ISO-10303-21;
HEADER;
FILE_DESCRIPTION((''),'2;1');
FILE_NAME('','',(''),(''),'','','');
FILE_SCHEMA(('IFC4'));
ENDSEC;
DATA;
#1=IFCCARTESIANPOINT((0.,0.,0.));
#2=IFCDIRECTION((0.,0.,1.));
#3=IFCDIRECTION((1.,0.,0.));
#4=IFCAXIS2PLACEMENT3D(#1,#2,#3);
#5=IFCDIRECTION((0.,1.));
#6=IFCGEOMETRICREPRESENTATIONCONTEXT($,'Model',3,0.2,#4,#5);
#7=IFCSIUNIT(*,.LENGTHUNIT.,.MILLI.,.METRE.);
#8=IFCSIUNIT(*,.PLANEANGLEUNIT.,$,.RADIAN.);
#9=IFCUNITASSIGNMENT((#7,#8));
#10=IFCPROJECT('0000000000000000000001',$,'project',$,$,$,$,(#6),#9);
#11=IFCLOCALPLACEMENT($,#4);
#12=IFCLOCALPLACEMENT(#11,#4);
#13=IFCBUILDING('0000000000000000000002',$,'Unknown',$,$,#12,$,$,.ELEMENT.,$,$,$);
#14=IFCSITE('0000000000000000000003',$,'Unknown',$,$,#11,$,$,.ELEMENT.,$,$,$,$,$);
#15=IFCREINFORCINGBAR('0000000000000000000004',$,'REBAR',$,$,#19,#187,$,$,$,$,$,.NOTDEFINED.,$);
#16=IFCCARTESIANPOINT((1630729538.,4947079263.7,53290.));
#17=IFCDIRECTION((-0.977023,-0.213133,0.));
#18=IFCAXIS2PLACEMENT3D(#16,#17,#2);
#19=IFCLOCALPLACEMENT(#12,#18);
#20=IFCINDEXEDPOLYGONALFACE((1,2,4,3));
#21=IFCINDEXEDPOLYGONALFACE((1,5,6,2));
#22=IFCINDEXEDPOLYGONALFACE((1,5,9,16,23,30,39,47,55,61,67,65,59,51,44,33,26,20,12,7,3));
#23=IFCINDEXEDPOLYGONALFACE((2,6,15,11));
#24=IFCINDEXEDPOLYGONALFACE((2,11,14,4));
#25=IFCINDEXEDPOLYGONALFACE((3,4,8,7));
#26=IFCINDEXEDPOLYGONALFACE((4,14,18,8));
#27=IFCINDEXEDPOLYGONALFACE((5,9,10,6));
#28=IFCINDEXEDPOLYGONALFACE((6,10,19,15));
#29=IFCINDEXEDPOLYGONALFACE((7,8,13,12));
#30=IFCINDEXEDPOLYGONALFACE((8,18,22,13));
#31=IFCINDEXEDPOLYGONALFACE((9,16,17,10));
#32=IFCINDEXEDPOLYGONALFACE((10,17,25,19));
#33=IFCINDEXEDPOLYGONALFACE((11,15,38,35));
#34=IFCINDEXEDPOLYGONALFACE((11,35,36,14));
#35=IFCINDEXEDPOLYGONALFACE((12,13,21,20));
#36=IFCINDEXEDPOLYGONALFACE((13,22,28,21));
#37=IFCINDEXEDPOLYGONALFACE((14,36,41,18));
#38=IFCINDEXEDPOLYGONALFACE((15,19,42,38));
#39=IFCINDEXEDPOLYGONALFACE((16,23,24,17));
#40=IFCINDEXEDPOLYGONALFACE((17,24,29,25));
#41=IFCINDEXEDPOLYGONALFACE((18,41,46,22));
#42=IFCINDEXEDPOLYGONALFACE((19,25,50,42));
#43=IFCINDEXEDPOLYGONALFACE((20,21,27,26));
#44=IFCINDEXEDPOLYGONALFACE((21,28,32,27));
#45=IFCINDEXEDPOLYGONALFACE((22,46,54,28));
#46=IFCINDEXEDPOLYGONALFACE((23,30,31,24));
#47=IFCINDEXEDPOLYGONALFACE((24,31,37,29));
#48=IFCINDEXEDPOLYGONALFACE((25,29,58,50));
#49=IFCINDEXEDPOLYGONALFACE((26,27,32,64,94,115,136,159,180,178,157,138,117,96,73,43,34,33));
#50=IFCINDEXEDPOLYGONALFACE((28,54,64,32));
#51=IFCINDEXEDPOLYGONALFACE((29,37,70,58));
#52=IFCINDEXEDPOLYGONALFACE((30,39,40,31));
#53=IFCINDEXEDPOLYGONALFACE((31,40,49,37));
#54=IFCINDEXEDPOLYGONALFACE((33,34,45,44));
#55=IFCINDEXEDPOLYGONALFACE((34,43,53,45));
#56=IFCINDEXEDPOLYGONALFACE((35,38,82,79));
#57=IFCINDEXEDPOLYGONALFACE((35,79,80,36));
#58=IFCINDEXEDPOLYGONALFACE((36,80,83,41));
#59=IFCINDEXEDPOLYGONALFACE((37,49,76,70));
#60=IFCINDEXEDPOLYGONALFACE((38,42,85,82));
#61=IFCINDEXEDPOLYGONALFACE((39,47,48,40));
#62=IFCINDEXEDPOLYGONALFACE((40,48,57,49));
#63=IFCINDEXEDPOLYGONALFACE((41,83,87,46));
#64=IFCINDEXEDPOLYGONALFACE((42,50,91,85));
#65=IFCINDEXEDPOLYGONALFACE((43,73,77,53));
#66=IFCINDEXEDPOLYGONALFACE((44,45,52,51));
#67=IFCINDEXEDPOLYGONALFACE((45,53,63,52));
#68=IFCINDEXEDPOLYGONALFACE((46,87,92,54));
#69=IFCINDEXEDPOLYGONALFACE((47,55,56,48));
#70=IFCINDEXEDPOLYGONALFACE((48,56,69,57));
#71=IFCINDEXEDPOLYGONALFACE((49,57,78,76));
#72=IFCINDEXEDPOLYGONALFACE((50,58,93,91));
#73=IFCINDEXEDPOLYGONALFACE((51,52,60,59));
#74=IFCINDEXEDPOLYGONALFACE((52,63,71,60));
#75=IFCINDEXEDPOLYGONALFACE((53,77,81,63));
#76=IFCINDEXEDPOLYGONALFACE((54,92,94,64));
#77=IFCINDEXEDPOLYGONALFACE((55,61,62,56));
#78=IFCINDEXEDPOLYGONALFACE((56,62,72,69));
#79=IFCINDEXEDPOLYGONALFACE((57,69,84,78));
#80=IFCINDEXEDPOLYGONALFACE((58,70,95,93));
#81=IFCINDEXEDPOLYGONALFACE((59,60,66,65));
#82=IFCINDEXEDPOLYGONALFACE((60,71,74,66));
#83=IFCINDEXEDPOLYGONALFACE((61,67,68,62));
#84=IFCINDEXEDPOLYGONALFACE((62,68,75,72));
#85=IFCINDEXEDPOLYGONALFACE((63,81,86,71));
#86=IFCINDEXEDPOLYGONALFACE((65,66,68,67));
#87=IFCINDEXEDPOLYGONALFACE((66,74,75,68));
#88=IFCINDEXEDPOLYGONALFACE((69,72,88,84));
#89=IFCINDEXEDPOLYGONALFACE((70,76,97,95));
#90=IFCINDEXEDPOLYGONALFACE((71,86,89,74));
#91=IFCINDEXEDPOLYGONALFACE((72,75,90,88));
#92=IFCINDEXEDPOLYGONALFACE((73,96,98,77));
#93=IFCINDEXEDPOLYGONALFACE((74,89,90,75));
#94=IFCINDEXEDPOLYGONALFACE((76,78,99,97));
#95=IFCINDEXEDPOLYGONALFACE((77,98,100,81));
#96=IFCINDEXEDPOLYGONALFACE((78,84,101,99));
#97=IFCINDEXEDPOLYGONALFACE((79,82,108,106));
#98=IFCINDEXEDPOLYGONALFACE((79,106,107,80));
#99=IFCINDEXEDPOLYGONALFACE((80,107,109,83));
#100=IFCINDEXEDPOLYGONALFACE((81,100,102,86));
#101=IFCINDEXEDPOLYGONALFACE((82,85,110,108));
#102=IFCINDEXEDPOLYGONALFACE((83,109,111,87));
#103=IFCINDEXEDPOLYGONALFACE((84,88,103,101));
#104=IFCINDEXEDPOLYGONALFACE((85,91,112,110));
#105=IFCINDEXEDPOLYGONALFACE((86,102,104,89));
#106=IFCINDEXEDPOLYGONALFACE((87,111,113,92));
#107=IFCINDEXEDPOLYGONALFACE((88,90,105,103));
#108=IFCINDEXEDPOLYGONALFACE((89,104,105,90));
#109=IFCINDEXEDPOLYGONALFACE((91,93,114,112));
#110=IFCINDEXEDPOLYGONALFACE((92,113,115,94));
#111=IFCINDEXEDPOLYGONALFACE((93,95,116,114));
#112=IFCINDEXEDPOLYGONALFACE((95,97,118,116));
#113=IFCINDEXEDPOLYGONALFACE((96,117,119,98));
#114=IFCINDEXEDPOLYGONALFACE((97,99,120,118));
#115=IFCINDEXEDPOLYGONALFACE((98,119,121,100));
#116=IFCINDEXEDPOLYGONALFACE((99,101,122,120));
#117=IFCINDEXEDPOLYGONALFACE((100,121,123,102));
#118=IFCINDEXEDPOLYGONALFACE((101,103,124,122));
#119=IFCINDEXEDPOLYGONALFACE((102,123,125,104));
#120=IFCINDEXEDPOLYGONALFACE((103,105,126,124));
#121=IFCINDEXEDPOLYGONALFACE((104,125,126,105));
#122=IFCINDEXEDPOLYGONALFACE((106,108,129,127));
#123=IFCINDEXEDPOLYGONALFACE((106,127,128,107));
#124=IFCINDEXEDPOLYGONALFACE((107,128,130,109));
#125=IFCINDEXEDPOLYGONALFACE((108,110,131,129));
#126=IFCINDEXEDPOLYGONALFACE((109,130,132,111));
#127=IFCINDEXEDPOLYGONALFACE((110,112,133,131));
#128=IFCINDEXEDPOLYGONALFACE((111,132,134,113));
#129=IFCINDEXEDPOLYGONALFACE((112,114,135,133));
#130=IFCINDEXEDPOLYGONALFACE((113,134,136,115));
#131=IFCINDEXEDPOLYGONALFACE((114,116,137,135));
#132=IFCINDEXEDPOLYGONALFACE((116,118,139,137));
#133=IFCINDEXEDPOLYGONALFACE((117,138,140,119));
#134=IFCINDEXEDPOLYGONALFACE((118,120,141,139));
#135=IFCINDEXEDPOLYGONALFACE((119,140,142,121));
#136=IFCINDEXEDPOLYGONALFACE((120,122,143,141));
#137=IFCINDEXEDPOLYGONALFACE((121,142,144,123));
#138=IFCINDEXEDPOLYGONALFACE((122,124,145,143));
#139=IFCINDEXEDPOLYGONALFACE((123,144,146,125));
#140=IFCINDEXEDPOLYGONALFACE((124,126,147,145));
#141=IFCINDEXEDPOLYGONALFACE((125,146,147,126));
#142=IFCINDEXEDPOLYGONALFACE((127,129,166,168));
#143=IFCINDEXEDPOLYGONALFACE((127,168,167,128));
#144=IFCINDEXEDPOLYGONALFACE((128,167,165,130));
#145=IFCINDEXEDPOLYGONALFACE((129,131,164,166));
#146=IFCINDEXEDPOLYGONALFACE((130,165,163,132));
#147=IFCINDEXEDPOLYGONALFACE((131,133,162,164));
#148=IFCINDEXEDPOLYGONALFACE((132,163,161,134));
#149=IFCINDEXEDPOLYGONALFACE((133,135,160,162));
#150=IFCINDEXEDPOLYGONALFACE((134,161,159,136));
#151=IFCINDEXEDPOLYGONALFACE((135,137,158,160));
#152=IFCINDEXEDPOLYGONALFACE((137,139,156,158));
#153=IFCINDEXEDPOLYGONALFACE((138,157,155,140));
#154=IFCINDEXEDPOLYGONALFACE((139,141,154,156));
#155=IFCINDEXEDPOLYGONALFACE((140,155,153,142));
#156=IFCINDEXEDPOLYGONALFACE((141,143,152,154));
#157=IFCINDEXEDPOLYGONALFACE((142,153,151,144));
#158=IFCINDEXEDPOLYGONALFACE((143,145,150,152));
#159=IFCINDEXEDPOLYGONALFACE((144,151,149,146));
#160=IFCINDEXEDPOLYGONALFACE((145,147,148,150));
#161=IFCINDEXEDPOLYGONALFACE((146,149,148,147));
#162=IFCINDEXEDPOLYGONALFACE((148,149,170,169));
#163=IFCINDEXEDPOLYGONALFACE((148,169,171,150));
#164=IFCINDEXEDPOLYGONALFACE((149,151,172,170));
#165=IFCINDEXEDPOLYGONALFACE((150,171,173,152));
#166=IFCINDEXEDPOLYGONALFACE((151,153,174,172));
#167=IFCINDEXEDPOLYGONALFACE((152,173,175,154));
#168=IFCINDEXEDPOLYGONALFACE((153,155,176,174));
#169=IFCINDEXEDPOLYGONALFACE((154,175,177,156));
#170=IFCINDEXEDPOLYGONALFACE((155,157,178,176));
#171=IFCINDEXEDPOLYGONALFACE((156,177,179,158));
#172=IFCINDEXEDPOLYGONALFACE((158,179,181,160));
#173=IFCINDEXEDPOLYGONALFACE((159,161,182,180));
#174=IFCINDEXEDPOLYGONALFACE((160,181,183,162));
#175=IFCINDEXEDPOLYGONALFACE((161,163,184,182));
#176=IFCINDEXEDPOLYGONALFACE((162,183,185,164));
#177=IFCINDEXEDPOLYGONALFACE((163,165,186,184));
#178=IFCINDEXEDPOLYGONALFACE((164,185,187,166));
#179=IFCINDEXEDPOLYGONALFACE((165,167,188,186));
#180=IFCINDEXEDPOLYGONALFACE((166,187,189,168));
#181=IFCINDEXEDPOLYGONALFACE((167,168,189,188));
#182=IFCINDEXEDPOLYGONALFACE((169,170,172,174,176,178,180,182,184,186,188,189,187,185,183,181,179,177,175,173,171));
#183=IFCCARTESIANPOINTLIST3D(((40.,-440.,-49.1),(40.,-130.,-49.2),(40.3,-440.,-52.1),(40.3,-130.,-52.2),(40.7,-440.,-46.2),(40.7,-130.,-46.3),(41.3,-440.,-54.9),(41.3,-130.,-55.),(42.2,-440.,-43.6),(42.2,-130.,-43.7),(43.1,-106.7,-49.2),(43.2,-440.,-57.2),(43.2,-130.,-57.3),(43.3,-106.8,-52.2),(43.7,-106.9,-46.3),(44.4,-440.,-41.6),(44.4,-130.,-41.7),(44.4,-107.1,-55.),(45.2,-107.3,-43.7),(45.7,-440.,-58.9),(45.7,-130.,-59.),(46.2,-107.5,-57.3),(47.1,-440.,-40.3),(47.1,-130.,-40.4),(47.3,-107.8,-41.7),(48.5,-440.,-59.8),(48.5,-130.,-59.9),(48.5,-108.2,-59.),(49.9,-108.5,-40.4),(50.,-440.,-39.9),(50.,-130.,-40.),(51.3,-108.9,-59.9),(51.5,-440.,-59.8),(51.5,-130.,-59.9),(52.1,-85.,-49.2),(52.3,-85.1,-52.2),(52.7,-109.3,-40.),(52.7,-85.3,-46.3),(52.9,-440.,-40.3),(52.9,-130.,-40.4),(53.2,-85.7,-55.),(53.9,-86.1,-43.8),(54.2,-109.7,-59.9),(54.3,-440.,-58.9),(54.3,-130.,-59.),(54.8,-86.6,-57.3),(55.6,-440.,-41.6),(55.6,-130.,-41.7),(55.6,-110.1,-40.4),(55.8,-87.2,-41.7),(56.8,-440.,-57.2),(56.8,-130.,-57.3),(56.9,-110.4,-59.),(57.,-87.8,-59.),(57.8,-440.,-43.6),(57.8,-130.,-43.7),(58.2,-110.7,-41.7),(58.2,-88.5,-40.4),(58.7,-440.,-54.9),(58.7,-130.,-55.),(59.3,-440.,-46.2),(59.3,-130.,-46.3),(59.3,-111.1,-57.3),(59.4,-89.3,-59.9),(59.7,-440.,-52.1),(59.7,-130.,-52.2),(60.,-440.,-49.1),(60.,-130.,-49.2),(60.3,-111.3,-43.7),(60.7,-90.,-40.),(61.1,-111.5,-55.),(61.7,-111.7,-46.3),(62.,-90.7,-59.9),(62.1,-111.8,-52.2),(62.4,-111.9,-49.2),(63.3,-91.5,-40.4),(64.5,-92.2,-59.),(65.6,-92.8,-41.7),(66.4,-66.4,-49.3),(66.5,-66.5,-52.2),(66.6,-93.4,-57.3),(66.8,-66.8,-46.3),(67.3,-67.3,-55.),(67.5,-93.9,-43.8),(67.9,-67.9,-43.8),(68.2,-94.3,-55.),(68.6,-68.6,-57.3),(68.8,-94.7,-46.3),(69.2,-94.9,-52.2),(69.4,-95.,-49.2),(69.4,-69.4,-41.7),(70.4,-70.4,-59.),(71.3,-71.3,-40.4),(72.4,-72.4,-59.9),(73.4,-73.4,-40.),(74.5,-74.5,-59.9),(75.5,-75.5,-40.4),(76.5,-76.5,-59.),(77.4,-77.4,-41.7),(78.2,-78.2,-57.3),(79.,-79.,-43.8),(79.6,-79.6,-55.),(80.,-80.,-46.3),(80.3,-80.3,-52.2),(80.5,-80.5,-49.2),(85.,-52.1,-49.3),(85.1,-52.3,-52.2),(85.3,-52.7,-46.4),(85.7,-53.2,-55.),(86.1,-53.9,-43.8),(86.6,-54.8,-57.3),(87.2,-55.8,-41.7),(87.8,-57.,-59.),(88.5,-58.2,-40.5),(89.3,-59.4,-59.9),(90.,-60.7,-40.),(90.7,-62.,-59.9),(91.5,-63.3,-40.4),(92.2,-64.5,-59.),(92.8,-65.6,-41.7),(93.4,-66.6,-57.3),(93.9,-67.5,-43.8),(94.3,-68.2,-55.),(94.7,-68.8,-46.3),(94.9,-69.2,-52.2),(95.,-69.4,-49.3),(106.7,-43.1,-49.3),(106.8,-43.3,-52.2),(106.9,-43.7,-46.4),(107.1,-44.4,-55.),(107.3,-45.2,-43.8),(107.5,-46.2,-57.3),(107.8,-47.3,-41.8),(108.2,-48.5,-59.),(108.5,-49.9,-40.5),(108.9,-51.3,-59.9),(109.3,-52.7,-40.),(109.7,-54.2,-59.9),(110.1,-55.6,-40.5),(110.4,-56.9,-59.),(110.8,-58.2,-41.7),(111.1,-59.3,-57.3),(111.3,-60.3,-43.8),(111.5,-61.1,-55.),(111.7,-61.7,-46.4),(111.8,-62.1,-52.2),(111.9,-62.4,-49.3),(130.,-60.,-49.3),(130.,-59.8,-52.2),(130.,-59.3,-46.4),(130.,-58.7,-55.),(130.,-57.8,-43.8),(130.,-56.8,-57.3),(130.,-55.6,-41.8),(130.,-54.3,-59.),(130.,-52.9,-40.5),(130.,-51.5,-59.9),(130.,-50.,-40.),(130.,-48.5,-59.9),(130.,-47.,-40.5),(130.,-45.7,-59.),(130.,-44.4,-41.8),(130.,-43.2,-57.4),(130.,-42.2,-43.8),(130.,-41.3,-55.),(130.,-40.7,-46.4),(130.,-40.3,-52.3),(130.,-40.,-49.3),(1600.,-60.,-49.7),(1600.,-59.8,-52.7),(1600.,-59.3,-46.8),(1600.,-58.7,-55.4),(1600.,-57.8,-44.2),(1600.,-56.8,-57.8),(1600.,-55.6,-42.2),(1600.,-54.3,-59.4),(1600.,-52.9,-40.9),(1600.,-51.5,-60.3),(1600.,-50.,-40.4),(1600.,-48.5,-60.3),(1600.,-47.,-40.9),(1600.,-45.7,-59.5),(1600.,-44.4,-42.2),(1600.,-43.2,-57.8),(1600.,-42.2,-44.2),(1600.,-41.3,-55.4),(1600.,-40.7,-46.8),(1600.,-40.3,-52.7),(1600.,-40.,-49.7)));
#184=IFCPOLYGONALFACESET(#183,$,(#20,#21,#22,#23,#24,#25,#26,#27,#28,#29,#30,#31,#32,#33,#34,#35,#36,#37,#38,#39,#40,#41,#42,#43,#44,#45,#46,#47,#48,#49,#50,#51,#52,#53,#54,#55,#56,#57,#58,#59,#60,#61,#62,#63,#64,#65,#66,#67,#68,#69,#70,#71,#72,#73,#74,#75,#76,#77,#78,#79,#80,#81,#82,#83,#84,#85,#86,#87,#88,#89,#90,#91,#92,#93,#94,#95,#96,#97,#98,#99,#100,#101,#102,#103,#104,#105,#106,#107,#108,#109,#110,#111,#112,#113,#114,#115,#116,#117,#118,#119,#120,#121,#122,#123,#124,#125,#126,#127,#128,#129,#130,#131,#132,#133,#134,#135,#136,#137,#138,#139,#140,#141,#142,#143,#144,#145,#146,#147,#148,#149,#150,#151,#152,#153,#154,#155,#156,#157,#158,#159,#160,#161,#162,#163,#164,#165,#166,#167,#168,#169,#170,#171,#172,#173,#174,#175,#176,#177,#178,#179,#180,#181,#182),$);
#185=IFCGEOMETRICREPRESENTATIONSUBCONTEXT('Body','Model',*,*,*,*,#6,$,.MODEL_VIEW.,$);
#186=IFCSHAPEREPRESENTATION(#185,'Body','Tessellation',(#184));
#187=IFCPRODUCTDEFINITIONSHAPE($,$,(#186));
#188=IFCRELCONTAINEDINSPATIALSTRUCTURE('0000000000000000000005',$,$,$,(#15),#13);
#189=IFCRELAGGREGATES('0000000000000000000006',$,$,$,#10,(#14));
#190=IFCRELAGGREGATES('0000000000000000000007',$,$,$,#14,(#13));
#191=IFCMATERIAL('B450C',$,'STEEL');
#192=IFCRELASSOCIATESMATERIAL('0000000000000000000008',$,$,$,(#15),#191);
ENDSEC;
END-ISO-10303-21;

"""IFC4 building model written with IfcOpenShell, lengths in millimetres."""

from ifc_helpers import new_model, entity, si_unit, direction, frame, origin_with_axes, place, context, subcontext, project, spatial, material, element, save


model = new_model("IFC4")

# Units and contexts
model_context = context("Model", 3, precision=0.2, world=origin_with_axes(), true_north=direction((0.0, 1.0)))
body_context = subcontext(model_context, "Body", "Model", "MODEL_VIEW")
ifc_project = project(units=[si_unit("LENGTHUNIT", "METRE", prefix="MILLI"), si_unit("PLANEANGLEUNIT", "RADIAN")], contexts=[model_context])

# Site, building
site_placement = place(None, origin_with_axes())
site = spatial("IfcSite", under=ifc_project, at=site_placement, Name="Unknown", CompositionType="ELEMENT")
building_placement = place(site_placement, origin_with_axes())
building = spatial("IfcBuilding", under=site, at=building_placement, Name="Unknown", CompositionType="ELEMENT")

# Reinforcing bar
ifc_material = material(Name="B450C", Category="STEEL")
reinforcing_bar_1_placement = place(building_placement, frame((1630729538.0, 4947079263.7, 53290.0), z_axis=(-0.977023, -0.213133, 0.0), x_axis=(0.0, 0.0, 1.0)))
element("IfcReinforcingBar", 1, at=reinforcing_bar_1_placement, inside=building, material=ifc_material, Name="REBAR", PredefinedType="NOTDEFINED", context=body_context, shape_type="AdvancedSweptSolid", body=[
    entity("IfcSweptDiskSolid", entity("IfcIndexedPolyCurve", entity("IfcCartesianPointList3D", [[50.0, -440.0, -49.9], [50.0, -130.0, -50.0], [73.4, -73.4, -50.0], [130.0, -50.0, -50.0], [1600.0, -50.0, -50.4]]), [entity("IfcLineIndex", [1, 2]), entity("IfcArcIndex", [2, 3, 4]), entity("IfcLineIndex", [4, 5])]), 10.0),
])

save(model, "model.ifc")
